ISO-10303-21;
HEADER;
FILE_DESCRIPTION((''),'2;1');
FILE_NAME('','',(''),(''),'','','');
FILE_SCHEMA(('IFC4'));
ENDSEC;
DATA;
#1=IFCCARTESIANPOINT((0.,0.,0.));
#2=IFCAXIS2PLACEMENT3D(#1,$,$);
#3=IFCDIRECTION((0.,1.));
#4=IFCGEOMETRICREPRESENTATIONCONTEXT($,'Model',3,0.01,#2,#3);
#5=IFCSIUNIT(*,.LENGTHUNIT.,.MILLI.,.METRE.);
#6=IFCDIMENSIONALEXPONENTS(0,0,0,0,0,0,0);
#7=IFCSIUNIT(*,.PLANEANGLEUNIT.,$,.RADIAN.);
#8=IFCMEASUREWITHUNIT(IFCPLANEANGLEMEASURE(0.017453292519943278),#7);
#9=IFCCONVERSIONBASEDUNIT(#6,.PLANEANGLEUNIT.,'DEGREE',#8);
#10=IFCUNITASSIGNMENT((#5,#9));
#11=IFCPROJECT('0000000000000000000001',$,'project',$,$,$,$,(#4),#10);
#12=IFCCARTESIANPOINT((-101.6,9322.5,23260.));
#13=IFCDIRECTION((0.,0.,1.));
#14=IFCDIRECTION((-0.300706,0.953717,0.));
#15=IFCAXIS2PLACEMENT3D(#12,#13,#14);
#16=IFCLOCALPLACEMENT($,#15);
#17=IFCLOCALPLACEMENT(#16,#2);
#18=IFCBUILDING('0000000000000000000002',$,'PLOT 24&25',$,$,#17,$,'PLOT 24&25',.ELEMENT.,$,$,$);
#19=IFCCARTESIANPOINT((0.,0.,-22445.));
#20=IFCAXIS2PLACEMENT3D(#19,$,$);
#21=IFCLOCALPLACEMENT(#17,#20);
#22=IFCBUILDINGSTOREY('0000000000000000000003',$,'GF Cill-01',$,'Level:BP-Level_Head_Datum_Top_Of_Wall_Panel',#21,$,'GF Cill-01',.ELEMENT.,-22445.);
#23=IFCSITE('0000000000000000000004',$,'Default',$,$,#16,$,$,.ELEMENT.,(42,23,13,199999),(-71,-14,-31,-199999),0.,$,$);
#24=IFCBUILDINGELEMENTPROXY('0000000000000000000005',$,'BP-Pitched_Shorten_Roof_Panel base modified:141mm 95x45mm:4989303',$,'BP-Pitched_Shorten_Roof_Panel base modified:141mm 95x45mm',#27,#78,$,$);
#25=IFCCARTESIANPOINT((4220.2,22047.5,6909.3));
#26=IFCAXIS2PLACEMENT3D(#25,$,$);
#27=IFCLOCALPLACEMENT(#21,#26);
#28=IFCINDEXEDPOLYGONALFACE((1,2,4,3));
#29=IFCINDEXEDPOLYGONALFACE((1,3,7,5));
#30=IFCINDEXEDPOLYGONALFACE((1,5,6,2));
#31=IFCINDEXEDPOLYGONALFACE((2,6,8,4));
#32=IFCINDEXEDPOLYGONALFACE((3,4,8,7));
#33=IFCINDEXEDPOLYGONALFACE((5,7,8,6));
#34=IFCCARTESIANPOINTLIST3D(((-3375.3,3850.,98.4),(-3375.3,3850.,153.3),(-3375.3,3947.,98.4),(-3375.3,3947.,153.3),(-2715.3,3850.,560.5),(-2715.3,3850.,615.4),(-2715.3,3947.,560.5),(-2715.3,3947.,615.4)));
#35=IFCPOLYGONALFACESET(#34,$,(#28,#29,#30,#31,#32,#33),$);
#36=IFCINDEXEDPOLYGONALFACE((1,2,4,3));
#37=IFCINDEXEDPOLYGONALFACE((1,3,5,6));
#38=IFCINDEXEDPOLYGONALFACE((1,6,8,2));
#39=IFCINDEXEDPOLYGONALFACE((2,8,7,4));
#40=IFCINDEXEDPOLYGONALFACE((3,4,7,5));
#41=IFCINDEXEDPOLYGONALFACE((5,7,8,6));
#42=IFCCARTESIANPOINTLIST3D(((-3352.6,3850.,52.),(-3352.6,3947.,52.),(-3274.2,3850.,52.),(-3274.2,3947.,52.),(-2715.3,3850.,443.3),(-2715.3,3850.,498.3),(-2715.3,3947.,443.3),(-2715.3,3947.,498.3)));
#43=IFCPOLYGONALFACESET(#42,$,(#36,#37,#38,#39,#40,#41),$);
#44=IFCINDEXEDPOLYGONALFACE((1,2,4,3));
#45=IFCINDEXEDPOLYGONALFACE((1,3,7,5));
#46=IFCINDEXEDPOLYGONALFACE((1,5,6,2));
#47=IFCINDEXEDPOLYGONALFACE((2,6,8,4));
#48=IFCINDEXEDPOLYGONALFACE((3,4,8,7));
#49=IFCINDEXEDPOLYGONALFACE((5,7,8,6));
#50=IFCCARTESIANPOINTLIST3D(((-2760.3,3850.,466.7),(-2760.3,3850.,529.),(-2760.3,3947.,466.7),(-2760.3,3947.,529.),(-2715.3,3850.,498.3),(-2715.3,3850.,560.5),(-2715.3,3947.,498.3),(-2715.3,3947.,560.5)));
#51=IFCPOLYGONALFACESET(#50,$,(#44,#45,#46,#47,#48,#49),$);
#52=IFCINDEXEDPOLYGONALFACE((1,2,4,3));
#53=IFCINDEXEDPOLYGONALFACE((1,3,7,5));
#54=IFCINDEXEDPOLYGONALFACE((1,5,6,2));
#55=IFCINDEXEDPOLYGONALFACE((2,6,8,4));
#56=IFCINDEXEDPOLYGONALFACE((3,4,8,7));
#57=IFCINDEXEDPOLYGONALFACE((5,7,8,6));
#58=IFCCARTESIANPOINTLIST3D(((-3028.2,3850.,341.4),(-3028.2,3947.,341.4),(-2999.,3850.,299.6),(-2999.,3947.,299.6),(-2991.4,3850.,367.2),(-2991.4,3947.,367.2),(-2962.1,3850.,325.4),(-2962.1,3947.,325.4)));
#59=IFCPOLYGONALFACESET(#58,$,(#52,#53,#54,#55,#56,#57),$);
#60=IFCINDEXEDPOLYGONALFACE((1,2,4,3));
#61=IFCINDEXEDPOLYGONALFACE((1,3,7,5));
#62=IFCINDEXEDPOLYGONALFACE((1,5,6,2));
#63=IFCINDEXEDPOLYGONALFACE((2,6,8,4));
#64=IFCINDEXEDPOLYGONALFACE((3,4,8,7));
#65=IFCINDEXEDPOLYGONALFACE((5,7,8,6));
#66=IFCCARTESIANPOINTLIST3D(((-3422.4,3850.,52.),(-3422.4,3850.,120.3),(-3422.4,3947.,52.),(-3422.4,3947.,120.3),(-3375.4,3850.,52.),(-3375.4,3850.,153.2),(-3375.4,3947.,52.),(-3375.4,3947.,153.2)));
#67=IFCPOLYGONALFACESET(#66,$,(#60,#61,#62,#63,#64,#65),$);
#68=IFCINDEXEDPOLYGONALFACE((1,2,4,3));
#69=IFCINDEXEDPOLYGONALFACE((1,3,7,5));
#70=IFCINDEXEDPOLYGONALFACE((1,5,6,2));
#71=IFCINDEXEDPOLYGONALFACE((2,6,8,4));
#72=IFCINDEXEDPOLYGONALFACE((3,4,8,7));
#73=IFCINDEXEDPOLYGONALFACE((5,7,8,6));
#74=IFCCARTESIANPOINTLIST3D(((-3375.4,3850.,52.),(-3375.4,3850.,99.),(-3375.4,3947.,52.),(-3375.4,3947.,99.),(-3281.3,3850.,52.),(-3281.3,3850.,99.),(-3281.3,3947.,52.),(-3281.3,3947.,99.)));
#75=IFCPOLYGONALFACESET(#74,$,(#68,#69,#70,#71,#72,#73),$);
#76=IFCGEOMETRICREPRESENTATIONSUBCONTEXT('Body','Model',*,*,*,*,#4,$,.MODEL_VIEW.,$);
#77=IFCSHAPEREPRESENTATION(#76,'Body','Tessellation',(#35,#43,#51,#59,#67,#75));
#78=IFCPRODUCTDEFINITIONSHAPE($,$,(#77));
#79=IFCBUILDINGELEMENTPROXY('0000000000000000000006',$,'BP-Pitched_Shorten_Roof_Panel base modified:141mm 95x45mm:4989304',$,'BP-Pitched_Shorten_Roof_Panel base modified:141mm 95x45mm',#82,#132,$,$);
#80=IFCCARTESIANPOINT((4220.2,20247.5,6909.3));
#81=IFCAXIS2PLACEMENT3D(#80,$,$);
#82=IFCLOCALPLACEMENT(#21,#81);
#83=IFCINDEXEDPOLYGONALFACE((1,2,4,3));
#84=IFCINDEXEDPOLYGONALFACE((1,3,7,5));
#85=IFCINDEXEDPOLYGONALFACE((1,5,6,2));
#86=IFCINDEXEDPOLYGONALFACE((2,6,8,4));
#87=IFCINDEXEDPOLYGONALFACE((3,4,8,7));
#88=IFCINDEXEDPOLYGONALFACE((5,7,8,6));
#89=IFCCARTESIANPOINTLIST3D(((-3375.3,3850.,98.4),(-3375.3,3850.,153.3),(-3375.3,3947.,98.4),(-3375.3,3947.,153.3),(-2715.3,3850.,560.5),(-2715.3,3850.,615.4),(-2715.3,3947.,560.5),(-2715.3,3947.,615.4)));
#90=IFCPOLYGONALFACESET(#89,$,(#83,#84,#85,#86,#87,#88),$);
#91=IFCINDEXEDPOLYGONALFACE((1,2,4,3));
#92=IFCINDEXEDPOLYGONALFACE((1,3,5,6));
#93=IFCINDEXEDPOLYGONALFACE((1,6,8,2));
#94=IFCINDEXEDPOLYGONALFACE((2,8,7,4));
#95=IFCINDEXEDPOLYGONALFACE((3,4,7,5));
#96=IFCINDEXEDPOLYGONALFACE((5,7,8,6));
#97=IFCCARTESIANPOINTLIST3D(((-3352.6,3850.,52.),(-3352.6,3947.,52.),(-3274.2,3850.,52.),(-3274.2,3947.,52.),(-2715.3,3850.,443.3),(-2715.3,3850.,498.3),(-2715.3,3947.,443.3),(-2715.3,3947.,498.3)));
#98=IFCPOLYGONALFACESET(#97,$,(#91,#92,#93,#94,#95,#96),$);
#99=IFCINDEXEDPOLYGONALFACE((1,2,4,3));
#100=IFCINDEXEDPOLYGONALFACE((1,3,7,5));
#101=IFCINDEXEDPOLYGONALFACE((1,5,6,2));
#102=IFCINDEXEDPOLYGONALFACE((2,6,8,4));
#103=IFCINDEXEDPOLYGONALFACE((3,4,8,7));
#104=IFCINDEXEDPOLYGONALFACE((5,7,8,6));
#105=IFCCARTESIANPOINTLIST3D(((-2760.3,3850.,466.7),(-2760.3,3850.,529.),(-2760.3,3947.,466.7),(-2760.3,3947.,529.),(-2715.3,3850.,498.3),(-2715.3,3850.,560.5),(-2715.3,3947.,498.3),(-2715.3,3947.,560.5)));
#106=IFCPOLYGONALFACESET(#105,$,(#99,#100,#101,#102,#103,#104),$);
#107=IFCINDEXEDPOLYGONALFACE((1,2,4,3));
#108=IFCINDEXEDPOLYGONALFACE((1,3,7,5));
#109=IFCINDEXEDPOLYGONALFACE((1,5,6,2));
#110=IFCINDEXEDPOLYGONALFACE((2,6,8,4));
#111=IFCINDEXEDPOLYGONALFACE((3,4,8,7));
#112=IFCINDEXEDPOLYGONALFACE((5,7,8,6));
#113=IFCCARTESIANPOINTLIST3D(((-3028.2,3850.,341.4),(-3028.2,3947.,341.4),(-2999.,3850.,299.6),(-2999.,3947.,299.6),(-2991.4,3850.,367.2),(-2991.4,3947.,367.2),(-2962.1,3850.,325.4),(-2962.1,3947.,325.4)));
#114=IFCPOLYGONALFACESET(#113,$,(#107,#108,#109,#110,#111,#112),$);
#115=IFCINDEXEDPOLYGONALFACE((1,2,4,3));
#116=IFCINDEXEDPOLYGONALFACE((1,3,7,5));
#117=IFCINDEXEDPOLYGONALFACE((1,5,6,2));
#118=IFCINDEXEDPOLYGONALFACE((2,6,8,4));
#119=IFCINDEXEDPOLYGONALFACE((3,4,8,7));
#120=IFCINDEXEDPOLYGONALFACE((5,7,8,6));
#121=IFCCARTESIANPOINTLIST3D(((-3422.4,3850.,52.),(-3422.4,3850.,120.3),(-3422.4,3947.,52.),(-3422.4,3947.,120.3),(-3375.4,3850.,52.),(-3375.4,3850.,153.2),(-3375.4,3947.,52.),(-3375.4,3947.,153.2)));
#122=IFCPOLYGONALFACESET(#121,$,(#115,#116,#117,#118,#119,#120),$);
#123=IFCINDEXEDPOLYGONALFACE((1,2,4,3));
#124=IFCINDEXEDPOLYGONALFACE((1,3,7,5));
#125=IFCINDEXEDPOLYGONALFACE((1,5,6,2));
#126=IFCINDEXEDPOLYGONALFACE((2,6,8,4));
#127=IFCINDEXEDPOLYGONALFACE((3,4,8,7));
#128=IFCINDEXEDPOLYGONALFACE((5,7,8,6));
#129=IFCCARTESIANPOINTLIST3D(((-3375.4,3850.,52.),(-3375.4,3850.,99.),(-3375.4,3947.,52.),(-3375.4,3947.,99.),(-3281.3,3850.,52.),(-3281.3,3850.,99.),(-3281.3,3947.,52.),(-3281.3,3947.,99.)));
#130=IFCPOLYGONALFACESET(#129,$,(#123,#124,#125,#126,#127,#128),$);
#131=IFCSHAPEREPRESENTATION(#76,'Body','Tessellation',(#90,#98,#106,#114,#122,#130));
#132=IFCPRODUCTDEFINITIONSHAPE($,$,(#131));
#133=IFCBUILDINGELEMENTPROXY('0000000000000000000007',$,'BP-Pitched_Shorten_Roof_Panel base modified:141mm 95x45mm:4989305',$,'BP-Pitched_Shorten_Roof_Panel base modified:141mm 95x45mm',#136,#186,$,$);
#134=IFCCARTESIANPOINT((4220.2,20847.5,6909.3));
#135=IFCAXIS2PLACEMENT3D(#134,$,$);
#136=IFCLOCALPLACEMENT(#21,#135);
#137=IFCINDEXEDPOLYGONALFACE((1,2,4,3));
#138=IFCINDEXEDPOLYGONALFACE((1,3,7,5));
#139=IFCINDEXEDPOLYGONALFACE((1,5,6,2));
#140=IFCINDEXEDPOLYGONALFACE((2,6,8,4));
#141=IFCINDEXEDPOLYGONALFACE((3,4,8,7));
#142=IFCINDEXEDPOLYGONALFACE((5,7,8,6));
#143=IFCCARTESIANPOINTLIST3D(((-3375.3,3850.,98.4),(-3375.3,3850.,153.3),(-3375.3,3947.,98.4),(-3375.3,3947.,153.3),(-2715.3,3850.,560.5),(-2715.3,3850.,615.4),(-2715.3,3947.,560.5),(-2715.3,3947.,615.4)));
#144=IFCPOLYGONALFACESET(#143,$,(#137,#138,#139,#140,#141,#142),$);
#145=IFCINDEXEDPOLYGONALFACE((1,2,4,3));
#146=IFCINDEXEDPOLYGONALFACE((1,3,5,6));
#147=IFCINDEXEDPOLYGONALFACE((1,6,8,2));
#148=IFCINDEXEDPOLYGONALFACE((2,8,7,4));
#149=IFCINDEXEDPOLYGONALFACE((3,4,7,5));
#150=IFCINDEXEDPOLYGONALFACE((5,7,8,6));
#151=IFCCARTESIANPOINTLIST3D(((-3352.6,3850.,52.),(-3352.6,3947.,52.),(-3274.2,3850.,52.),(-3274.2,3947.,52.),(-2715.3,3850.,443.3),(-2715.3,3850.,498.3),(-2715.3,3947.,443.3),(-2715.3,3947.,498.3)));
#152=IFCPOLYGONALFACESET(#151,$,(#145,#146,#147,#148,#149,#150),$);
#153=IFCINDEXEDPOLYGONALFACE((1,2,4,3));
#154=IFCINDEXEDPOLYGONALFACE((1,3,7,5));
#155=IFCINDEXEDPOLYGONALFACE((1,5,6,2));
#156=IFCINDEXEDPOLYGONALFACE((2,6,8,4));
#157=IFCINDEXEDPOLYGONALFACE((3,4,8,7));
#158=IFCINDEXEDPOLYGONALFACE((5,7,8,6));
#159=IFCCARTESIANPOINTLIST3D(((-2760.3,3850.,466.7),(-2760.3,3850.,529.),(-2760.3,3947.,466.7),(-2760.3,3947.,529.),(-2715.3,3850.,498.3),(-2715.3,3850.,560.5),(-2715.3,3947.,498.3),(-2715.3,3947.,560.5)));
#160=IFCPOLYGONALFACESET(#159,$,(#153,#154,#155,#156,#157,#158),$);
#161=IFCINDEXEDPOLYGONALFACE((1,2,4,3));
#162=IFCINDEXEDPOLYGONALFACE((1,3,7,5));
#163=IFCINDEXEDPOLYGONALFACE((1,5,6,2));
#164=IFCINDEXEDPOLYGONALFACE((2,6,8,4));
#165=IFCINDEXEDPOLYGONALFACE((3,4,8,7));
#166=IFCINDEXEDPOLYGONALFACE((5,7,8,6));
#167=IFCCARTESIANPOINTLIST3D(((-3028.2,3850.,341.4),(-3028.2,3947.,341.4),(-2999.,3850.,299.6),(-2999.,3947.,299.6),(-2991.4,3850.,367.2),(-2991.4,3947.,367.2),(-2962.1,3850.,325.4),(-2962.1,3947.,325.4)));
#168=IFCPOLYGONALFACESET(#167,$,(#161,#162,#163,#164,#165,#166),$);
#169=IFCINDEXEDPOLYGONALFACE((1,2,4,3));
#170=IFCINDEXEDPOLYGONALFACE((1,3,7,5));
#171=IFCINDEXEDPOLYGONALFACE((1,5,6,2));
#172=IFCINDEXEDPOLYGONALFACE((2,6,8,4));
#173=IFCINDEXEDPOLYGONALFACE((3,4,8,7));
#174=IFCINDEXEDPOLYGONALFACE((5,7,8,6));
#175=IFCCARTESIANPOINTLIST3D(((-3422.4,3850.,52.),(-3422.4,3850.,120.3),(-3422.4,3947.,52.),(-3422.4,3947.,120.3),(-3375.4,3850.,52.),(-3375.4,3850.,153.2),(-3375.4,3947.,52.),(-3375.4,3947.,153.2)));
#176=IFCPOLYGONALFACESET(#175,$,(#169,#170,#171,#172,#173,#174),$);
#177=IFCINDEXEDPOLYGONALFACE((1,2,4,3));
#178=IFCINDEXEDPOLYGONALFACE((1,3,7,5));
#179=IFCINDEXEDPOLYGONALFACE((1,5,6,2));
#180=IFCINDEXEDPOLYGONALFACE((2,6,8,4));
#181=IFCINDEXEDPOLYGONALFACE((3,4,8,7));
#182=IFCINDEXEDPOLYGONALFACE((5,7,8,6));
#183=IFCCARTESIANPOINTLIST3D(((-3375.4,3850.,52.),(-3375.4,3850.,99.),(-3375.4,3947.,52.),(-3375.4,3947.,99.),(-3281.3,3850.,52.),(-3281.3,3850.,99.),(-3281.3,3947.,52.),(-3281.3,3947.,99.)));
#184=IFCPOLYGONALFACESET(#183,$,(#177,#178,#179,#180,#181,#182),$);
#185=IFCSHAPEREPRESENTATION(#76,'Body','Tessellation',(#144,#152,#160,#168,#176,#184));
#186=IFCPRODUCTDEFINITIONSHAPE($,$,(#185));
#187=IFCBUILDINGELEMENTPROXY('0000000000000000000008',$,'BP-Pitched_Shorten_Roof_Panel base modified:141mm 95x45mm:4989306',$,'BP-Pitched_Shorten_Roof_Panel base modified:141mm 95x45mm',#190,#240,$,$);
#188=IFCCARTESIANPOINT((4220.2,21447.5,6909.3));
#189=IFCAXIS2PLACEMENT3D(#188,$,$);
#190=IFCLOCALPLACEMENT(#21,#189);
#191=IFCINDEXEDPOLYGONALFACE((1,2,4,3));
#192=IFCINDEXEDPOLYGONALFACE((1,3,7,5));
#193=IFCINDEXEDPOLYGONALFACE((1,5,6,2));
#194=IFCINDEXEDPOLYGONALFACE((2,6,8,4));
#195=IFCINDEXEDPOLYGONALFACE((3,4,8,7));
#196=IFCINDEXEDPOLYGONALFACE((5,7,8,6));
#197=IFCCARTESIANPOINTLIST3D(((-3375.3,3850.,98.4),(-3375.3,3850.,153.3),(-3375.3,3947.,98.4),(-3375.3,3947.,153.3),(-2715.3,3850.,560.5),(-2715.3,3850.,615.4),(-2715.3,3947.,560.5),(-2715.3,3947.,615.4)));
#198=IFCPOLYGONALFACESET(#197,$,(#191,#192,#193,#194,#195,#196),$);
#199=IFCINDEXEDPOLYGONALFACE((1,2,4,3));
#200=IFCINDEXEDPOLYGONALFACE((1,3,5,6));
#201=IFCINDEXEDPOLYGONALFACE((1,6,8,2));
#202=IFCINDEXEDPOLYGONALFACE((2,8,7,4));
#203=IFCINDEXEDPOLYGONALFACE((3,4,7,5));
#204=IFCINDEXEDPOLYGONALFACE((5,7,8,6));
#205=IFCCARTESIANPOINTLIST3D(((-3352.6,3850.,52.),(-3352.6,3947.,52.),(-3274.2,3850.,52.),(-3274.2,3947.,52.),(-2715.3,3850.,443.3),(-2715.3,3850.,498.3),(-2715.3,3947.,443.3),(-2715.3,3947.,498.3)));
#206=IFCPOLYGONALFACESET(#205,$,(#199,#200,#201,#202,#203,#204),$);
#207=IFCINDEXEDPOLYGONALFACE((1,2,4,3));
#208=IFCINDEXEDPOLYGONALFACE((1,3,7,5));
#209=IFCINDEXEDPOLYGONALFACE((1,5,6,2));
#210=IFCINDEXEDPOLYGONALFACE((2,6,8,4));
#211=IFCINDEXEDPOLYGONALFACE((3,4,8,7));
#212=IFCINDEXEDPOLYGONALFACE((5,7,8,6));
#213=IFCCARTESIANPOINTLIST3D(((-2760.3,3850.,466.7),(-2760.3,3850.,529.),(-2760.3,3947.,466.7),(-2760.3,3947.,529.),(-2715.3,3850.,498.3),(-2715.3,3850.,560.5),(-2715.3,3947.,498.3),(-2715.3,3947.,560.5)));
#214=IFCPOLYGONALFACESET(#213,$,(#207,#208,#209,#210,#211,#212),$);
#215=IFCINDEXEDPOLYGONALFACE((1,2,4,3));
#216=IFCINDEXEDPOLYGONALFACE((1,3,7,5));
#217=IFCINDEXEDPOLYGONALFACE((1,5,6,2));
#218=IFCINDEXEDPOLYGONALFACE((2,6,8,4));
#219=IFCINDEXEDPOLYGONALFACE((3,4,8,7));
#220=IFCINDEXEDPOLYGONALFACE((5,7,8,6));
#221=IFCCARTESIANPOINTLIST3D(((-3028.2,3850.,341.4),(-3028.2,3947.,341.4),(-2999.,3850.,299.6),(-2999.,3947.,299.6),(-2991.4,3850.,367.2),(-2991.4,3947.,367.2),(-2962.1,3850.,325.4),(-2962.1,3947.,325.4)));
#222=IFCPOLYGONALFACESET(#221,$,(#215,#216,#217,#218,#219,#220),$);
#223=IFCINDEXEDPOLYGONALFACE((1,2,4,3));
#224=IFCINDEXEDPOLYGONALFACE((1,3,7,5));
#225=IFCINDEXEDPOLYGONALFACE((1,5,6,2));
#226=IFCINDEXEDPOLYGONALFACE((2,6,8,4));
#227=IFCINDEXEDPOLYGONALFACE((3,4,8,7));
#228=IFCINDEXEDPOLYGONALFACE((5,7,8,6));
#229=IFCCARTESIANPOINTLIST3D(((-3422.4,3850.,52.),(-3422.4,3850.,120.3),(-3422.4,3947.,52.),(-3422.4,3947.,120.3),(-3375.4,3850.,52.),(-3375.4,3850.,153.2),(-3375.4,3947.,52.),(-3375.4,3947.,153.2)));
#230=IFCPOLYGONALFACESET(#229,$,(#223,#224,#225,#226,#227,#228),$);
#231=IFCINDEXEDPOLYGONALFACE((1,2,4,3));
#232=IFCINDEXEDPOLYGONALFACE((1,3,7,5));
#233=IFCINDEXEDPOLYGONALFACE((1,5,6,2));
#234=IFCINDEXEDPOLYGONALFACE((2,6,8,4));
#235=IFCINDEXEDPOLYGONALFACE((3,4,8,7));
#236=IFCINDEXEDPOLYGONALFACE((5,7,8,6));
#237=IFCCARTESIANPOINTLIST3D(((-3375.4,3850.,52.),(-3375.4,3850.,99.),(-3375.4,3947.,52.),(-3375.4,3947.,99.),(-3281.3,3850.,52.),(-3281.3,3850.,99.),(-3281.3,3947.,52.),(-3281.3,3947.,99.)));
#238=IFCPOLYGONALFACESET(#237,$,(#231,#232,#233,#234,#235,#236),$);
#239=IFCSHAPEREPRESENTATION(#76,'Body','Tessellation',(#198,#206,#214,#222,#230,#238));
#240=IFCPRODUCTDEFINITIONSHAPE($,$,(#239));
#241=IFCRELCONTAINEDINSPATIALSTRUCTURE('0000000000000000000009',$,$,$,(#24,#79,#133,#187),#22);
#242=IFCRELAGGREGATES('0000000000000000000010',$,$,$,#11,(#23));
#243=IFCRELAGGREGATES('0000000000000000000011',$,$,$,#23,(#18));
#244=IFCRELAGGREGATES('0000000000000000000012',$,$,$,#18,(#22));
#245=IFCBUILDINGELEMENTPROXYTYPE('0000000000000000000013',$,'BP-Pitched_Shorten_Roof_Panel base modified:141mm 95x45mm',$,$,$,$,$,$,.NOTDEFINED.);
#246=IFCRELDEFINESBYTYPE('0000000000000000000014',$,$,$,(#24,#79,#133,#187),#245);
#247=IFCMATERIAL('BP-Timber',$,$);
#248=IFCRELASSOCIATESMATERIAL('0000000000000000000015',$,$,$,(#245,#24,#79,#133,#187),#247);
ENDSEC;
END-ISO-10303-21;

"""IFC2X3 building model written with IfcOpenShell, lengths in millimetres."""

from ifc_helpers import new_model, entity, si_unit, converted_unit, direction, frame, frame_2d, origin, origin_2d_with_axis, place, context, subcontext, project, spatial, polyline, rectangle, outline, extrude, source, transform, mapped, material, type_object, type_shapes, element, save


model = new_model("IFC2X3")

# Units and contexts
model_context = context("Model", 3, precision=0.01, world=origin(), true_north=direction((0.0, 1.0)))
body_context = subcontext(model_context, "Body", "Model", "MODEL_VIEW")
ifc_project = project(units=[si_unit("LENGTHUNIT", "METRE", prefix="MILLI"), converted_unit("PLANEANGLEUNIT", "DEGREE", entity("IfcPlaneAngleMeasure", 0.017453292519943278), si_unit("PLANEANGLEUNIT", "RADIAN"), dimensions=[0, 0, 0, 0, 0, 0, 0])], contexts=[model_context])

# Site, building, storey
site_placement = place(None, frame((-101.6, 9322.5, 23260.0), z_axis=(0.0, 0.0, 1.0), x_axis=(-0.300706, 0.953717, 0.0)))
site = spatial("IfcSite", under=ifc_project, at=site_placement, Name="Default", CompositionType="ELEMENT", RefLatitude=(42, 23, 13, 199999), RefLongitude=(-71, -14, -31, -199999), RefElevation=0.0)
building_placement = place(site_placement, origin())
building = spatial("IfcBuilding", under=site, at=building_placement, Name="PLOT 24&25", LongName="PLOT 24&25", CompositionType="ELEMENT")
storey_placement = place(building_placement, frame((0.0, 0.0, -22445.0)))
storey = spatial("IfcBuildingStorey", under=building, at=storey_placement, Name="GF Cill-01", ObjectType="Level:BP-Level_Head_Datum_Top_Of_Wall_Panel", LongName="GF Cill-01", CompositionType="ELEMENT", Elevation=-22445.0)

# Shared definitions
ifc_material_1 = material(Name="BP-Timber")

# Building element proxies
building_element_proxy_type_1 = type_object("IfcBuildingElementProxyType", Name="BP-Pitched_Shorten_Roof_Panel base modified:141mm 95x45mm", PredefinedType="NOTDEFINED", material=ifc_material_1)
shared_shape_1 = source(origin(), body_context, "Body", "SweptSolid", [
    extrude(outline(polyline([(-258.5, -330.0), (-203.6, -330.0), (258.5, 330.0), (203.6, 330.0), (-258.5, -330.0)])), frame((-3045.3, 3850.0, 356.9), z_axis=(0.0, 1.0, 0.0), x_axis=(0.0, 0.0, -1.0)), (0.0, 0.0, 1.0), 97.0),
    extrude(outline(polyline([(-236.9, -299.0), (-181.9, -299.0), (209.4, 259.8), (209.4, 338.3), (-236.9, -299.0)])), frame((-3014.4, 3850.0, 261.4), z_axis=(0.0, 1.0, 0.0), x_axis=(0.0, 0.0, -1.0)), (0.0, 0.0, 1.0), 97.0),
    extrude(outline(polyline([(-9.6, -25.5), (45.3, -25.5), (9.6, 25.5), (-45.3, 25.5), (-9.6, -25.5)])), frame((-2737.8, 3850.0, 513.6), z_axis=(0.0, 1.0, 0.0), x_axis=(0.819152, 0.0, 0.573576)), (0.0, 0.0, 1.0), 97.0),
    extrude(rectangle(XDim=51.0, YDim=45.0, at=origin_2d_with_axis()), frame((-2995.2, 3850.0, 333.4), z_axis=(0.0, 1.0, 0.0), x_axis=(0.573576, 0.0, -0.819152)), (0.0, 0.0, 1.0), 97.0),
    extrude(outline(polyline([(-58.9, -23.5), (42.4, -23.5), (42.4, 23.5), (-25.9, 23.5), (-58.9, -23.5)])), frame((-3398.9, 3850.0, 94.4), z_axis=(0.0, 1.0, 0.0), x_axis=(0.0, 0.0, -1.0)), (0.0, 0.0, 1.0), 97.0),
    extrude(rectangle(XDim=97.0, YDim=94.1, at=frame_2d((0.0, 0.0), x_axis=(1.0, 0.0))), frame((-3328.4, 3898.5, 52.0), z_axis=(0.0, 0.0, 1.0), x_axis=(0.0, 1.0, 0.0)), (0.0, 0.0, 1.0), 47.0),
])
type_shapes(building_element_proxy_type_1, [shared_shape_1])
for number, where, name in (
    (1, (4220.2, 22047.5, 6909.3), "BP-Pitched_Shorten_Roof_Panel base modified:141mm 95x45mm:4989303"),
    (2, (4220.2, 20247.5, 6909.3), "BP-Pitched_Shorten_Roof_Panel base modified:141mm 95x45mm:4989304"),
    (3, (4220.2, 20847.5, 6909.3), "BP-Pitched_Shorten_Roof_Panel base modified:141mm 95x45mm:4989305"),
    (4, (4220.2, 21447.5, 6909.3), "BP-Pitched_Shorten_Roof_Panel base modified:141mm 95x45mm:4989306"),
):
    element("IfcBuildingElementProxy", number, at=place(storey_placement, frame(where)), inside=storey, type_object=building_element_proxy_type_1, material=ifc_material_1, Name=name, ObjectType="BP-Pitched_Shorten_Roof_Panel base modified:141mm 95x45mm", context=body_context, shape_type="MappedRepresentation", body=[
        mapped(shared_shape_1, transform((0.0, 0.0, 0.0), scale=1.0)),
    ])

save(model, "model.ifc")
